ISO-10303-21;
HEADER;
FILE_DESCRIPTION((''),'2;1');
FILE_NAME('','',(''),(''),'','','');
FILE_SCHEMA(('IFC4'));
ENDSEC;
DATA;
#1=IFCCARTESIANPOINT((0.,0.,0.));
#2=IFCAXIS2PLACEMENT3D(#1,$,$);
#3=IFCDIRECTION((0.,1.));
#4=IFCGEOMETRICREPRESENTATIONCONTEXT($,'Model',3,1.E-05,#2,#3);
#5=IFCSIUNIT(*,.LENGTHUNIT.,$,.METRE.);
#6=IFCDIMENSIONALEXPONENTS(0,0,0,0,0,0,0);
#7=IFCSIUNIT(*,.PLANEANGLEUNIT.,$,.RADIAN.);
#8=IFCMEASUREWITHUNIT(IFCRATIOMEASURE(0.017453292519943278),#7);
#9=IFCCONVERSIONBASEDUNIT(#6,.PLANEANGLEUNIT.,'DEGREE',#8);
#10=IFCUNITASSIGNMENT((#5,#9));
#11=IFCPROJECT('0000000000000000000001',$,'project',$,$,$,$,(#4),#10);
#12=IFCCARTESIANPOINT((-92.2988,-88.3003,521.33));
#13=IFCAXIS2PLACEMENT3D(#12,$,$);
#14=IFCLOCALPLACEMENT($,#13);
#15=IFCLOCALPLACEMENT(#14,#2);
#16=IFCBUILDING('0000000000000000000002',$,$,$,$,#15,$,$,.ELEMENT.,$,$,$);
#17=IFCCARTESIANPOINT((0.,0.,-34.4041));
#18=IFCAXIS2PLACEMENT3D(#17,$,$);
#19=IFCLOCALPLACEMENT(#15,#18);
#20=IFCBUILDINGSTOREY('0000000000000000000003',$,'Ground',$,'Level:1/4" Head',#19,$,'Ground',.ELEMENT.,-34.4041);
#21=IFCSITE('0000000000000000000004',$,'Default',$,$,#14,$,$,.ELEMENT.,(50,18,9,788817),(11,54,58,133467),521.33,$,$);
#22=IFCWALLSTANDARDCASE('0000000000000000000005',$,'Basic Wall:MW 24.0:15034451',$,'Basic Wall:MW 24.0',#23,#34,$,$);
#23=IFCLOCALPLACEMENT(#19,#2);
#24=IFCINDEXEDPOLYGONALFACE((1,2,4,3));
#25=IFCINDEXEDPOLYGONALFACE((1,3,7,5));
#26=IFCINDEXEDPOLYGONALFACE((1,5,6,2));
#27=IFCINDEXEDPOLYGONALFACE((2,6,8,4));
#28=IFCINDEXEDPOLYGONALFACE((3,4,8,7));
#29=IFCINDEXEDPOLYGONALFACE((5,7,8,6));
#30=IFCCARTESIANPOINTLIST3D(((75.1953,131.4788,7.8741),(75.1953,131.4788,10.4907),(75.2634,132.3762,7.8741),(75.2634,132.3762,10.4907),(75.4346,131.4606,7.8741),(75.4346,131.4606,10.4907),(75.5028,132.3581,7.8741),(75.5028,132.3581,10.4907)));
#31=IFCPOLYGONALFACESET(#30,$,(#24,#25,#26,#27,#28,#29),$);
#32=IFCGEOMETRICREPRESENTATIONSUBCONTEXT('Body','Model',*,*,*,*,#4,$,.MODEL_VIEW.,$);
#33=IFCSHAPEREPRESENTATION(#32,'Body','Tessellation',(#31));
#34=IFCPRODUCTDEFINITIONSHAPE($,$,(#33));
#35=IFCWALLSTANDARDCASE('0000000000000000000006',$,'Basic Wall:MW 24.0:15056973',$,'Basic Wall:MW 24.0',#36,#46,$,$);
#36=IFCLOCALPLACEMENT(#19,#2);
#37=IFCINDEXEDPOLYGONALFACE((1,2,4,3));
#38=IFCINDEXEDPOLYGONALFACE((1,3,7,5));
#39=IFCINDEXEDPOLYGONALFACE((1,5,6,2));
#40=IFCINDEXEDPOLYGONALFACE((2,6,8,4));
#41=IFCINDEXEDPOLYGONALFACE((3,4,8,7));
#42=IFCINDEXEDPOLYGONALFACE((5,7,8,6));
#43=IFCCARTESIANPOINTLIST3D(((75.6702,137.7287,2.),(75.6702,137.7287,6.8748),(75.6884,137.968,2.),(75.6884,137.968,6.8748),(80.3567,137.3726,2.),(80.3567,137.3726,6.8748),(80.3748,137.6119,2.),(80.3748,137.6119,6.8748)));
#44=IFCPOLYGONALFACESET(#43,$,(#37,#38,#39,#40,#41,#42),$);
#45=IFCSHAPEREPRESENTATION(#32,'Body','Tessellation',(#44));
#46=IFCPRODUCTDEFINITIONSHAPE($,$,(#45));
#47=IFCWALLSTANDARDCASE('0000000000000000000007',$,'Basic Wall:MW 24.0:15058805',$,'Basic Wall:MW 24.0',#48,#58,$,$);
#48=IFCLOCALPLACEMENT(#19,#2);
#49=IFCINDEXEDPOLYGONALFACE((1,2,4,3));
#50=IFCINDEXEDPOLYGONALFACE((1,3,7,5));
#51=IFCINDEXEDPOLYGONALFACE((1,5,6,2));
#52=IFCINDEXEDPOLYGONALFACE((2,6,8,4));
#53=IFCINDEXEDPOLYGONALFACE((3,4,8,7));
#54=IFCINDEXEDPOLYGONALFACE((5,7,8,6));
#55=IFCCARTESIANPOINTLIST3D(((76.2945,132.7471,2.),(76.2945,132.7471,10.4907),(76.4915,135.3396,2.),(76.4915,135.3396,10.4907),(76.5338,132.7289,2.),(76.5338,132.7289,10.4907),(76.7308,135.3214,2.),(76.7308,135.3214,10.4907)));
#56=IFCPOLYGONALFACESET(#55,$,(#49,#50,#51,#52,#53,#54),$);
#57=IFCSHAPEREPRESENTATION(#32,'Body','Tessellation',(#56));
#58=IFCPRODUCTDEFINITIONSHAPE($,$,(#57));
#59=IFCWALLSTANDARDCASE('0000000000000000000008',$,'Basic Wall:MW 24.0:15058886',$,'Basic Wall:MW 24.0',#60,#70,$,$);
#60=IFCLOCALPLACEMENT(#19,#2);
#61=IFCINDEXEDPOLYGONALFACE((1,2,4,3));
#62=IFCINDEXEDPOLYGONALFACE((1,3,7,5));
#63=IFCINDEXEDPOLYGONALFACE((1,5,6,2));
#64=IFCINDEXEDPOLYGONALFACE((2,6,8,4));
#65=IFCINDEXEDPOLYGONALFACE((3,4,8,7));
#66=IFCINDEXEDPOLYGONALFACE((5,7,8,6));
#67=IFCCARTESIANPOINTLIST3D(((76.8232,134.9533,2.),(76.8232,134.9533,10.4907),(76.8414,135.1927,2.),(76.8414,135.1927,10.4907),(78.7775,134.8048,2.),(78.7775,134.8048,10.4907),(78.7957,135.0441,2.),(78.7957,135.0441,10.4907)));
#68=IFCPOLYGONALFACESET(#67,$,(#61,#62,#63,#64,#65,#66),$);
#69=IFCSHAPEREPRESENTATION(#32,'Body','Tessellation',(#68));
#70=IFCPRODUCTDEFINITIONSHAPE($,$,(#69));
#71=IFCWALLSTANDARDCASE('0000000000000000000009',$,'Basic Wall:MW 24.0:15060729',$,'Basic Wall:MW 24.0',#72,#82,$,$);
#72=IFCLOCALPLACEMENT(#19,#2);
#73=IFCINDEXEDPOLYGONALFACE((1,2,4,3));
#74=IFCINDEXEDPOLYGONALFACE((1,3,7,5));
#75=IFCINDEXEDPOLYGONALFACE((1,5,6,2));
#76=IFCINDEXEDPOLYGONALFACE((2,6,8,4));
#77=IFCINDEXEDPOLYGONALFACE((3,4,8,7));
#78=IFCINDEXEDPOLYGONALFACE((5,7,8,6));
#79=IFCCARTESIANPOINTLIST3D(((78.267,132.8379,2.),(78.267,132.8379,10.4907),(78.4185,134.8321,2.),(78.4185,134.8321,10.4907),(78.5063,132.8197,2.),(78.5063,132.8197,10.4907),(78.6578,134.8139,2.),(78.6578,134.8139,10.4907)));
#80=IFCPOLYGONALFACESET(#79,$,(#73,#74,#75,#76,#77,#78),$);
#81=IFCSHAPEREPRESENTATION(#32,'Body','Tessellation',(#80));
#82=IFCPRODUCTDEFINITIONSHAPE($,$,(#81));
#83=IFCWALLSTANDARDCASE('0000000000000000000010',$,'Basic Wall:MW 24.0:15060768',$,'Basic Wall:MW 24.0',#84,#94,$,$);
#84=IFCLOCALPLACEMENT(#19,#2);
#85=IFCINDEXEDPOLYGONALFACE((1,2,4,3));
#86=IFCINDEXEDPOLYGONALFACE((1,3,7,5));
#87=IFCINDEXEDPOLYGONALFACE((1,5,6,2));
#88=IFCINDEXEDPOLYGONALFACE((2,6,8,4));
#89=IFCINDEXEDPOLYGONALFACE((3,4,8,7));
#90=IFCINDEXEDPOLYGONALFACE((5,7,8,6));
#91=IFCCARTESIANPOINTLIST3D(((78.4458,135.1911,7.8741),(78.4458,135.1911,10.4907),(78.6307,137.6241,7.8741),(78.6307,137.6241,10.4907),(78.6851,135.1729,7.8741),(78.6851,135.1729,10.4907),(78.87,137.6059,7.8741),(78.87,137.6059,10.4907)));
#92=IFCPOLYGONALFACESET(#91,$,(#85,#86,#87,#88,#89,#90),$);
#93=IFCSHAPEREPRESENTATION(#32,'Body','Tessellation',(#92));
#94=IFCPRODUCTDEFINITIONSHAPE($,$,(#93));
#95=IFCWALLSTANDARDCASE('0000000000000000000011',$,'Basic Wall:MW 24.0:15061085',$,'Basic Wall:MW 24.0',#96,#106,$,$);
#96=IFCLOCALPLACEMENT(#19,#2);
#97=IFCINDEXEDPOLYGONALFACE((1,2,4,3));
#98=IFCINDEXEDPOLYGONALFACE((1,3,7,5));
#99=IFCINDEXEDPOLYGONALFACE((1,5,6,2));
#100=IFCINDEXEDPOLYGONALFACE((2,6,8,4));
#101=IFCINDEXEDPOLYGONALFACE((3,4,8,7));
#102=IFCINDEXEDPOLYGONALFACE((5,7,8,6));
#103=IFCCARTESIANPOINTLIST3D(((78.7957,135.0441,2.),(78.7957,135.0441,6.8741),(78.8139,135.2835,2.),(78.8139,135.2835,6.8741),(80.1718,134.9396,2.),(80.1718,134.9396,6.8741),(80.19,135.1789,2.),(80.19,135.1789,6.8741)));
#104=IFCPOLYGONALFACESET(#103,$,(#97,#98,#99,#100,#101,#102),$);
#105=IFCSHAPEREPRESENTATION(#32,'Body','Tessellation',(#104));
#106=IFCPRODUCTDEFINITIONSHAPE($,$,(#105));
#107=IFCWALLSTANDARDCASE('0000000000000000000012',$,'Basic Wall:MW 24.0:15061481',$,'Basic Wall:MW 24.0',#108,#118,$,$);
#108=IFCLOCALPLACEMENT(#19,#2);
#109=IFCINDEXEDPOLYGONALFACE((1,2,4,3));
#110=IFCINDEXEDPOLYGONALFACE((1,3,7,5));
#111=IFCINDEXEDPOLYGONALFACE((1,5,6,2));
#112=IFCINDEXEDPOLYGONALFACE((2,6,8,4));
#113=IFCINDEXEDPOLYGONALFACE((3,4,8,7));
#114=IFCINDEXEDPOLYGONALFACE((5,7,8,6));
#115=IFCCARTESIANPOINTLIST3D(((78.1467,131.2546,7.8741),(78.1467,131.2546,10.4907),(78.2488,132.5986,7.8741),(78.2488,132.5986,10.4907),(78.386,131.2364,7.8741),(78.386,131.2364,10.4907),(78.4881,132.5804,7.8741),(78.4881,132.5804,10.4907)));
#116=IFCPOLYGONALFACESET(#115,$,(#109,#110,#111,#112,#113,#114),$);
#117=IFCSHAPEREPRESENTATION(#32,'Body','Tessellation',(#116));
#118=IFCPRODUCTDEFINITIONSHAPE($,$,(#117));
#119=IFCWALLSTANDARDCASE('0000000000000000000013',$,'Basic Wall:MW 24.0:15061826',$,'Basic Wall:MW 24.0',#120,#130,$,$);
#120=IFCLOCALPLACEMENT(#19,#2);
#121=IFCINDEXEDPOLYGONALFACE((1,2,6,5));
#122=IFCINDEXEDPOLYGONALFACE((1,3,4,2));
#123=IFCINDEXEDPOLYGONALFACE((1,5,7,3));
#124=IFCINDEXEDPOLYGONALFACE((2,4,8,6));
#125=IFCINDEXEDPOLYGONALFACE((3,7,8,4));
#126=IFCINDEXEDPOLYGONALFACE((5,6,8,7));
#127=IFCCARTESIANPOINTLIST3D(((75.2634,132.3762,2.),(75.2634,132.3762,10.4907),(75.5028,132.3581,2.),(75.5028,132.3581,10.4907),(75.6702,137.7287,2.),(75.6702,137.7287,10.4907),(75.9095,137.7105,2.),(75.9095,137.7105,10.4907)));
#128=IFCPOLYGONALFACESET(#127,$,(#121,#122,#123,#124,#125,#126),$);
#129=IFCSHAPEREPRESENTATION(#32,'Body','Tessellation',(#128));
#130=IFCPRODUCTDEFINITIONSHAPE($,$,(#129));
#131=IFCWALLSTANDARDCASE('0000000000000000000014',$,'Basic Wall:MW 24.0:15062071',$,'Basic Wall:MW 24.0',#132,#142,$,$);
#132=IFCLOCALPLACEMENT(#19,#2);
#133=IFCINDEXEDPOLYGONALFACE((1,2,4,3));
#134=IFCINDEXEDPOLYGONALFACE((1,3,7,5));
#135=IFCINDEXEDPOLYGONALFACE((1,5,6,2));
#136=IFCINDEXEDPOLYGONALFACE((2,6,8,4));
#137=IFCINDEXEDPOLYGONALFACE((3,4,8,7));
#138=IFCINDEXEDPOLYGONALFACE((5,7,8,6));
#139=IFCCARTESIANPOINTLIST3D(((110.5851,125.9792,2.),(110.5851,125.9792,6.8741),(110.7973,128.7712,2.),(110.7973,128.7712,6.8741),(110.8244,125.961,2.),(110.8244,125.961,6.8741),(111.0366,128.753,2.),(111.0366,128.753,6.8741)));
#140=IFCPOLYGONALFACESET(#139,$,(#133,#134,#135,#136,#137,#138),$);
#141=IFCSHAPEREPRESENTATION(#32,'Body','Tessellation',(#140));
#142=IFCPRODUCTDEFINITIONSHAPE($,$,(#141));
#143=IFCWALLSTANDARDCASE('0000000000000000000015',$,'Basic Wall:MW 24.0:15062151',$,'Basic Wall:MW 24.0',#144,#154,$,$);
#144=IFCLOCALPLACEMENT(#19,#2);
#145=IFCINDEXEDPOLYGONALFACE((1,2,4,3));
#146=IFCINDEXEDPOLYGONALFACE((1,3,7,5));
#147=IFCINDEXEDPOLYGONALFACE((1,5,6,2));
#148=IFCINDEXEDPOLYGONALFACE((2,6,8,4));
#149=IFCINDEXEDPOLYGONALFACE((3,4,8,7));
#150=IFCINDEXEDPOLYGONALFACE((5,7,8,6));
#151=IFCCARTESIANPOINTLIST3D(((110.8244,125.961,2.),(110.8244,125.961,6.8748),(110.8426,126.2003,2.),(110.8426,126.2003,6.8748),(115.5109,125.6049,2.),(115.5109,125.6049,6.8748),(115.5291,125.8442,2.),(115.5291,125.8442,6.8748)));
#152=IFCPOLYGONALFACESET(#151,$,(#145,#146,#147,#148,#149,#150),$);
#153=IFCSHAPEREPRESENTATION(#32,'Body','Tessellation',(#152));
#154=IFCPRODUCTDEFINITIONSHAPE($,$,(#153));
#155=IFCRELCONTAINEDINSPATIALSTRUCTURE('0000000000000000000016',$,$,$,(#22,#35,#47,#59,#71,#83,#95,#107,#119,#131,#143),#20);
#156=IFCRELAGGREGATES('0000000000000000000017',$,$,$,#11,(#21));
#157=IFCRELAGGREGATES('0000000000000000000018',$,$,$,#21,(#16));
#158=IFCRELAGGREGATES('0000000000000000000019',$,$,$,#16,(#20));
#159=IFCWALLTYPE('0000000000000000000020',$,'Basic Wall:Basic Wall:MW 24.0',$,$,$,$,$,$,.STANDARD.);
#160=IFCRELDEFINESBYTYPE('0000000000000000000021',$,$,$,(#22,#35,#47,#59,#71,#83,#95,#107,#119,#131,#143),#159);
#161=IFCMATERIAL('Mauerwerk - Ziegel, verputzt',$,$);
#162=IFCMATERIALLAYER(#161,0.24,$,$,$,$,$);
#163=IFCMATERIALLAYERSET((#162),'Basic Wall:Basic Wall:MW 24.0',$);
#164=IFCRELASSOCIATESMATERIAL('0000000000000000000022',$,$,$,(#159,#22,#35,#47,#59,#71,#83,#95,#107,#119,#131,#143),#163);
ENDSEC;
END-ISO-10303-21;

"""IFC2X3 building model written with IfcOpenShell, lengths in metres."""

from ifc_helpers import new_model, entity, si_unit, converted_unit, direction, frame, frame_2d, origin, place, context, subcontext, project, spatial, rectangle, extrude, material, layer, layer_set, layer_usage, type_object, element, save


model = new_model("IFC2X3")

# Units and contexts
model_context = context("Model", 3, precision=1e-05, world=origin(), true_north=direction((0.0, 1.0)))
body_context = subcontext(model_context, "Body", "Model", "MODEL_VIEW")
ifc_project = project(units=[si_unit("LENGTHUNIT", "METRE"), converted_unit("PLANEANGLEUNIT", "DEGREE", entity("IfcRatioMeasure", 0.017453292519943278), si_unit("PLANEANGLEUNIT", "RADIAN"), dimensions=[0, 0, 0, 0, 0, 0, 0])], contexts=[model_context])

# Site, building, storey
site_placement = place(None, frame((-92.2988, -88.3003, 521.33)))
site = spatial("IfcSite", under=ifc_project, at=site_placement, Name="Default", CompositionType="ELEMENT", RefLatitude=(50, 18, 9, 788817), RefLongitude=(11, 54, 58, 133467), RefElevation=521.33)
building_placement = place(site_placement, origin())
building = spatial("IfcBuilding", under=site, at=building_placement, CompositionType="ELEMENT")
storey_placement = place(building_placement, frame((0.0, 0.0, -34.4041)))
storey = spatial("IfcBuildingStorey", under=building, at=storey_placement, Name="Ground", ObjectType="Level:1/4\" Head", LongName="Ground", CompositionType="ELEMENT", Elevation=-34.4041)

# Walls
ifc_material_1 = material(Name="Mauerwerk - Ziegel, verputzt")
ifc_layer = layer(ifc_material_1, 0.24)
ifc_layer_set = layer_set([ifc_layer], Name="Basic Wall:Basic Wall:MW 24.0")
wall_type_1 = type_object("IfcWallType", Name="Basic Wall:Basic Wall:MW 24.0", PredefinedType="STANDARD", material=ifc_layer_set)
ifc_layer_usage_1 = layer_usage(ifc_layer_set, "AXIS2", "NEGATIVE", 0.12)
wall_1_placement = place(storey_placement, frame((75.3149, 131.4697, 7.8741), z_axis=(0.0, 0.0, 1.0), x_axis=(0.07577, 0.997125, 0.0)))
element("IfcWallStandardCase", 1, at=wall_1_placement, inside=storey, type_object=wall_type_1, material=ifc_layer_usage_1, Name="Basic Wall:MW 24.0:15034451", ObjectType="Basic Wall:MW 24.0", context=body_context, shape_type="SweptSolid", body=[
    extrude(rectangle(XDim=0.9, YDim=0.24, at=frame_2d((0.45, 0.0), x_axis=(-1.0, 0.0))), origin(), (0.0, 0.0, 1.0), 2.6166),
])
ifc_layer_usage_2 = layer_usage(ifc_layer_set, "AXIS2", "NEGATIVE", 0.12)
wall_2_placement = place(storey_placement, frame((80.3657, 137.4922, 2.0), z_axis=(0.0, 0.0, 1.0), x_axis=(-0.997125, 0.07577, 0.0)))
element("IfcWallStandardCase", 2, at=wall_2_placement, inside=storey, type_object=wall_type_1, material=ifc_layer_usage_2, Name="Basic Wall:MW 24.0:15056973", ObjectType="Basic Wall:MW 24.0", context=body_context, shape_type="SweptSolid", body=[
    extrude(rectangle(XDim=4.7, YDim=0.24, at=frame_2d((2.35, 0.0), x_axis=(-1.0, 0.0))), origin(), (0.0, 0.0, 1.0), 4.8748),
])
ifc_layer_usage_3 = layer_usage(ifc_layer_set, "AXIS2", "NEGATIVE", 0.12)
wall_3_placement = place(storey_placement, frame((76.6112, 135.3305, 2.0), z_axis=(0.0, 0.0, 1.0), x_axis=(-0.07577, -0.997125, 0.0)))
element("IfcWallStandardCase", 3, at=wall_3_placement, inside=storey, type_object=wall_type_1, material=ifc_layer_usage_3, Name="Basic Wall:MW 24.0:15058805", ObjectType="Basic Wall:MW 24.0", context=body_context, shape_type="SweptSolid", body=[
    extrude(rectangle(XDim=2.6, YDim=0.24, at=frame_2d((1.3, 0.0), x_axis=(-1.0, 0.0))), origin(), (0.0, 0.0, 1.0), 8.4907),
])
ifc_layer_usage_4 = layer_usage(ifc_layer_set, "AXIS2", "NEGATIVE", 0.12)
wall_4_placement = place(storey_placement, frame((76.8323, 135.073, 2.0), z_axis=(0.0, 0.0, 1.0), x_axis=(0.997125, -0.07577, 0.0)))
element("IfcWallStandardCase", 4, at=wall_4_placement, inside=storey, type_object=wall_type_1, material=ifc_layer_usage_4, Name="Basic Wall:MW 24.0:15058886", ObjectType="Basic Wall:MW 24.0", context=body_context, shape_type="SweptSolid", body=[
    extrude(rectangle(XDim=1.9599, YDim=0.24, at=frame_2d((0.98, 0.0), x_axis=(-1.0, 0.0))), origin(), (0.0, 0.0, 1.0), 8.4907),
])
ifc_layer_usage_5 = layer_usage(ifc_layer_set, "AXIS2", "NEGATIVE", 0.12)
wall_5_placement = place(storey_placement, frame((78.5382, 134.823, 2.0), z_axis=(0.0, 0.0, 1.0), x_axis=(-0.07577, -0.997125, 0.0)))
element("IfcWallStandardCase", 5, at=wall_5_placement, inside=storey, type_object=wall_type_1, material=ifc_layer_usage_5, Name="Basic Wall:MW 24.0:15060729", ObjectType="Basic Wall:MW 24.0", context=body_context, shape_type="SweptSolid", body=[
    extrude(rectangle(XDim=2.0, YDim=0.24, at=frame_2d((1.0, 0.0), x_axis=(-1.0, 0.0))), origin(), (0.0, 0.0, 1.0), 8.4907),
])
ifc_layer_usage_6 = layer_usage(ifc_layer_set, "AXIS2", "NEGATIVE", 0.12)
wall_6_placement = place(storey_placement, frame((78.7503, 137.615, 7.8741), z_axis=(0.0, 0.0, 1.0), x_axis=(-0.07577, -0.997125, 0.0)))
element("IfcWallStandardCase", 6, at=wall_6_placement, inside=storey, type_object=wall_type_1, material=ifc_layer_usage_6, Name="Basic Wall:MW 24.0:15060768", ObjectType="Basic Wall:MW 24.0", context=body_context, shape_type="SweptSolid", body=[
    extrude(rectangle(XDim=2.44, YDim=0.24, at=frame_2d((1.22, 0.0), x_axis=(-1.0, 0.0))), origin(), (0.0, 0.0, 1.0), 2.6166),
])
ifc_layer_usage_7 = layer_usage(ifc_layer_set, "AXIS2", "NEGATIVE", 0.12)
wall_7_placement = place(storey_placement, frame((80.1809, 135.0592, 2.0), z_axis=(0.0, 0.0, 1.0), x_axis=(-0.997125, 0.07577, 0.0)))
element("IfcWallStandardCase", 7, at=wall_7_placement, inside=storey, type_object=wall_type_1, material=ifc_layer_usage_7, Name="Basic Wall:MW 24.0:15061085", ObjectType="Basic Wall:MW 24.0", context=body_context, shape_type="SweptSolid", body=[
    extrude(rectangle(XDim=1.3801, YDim=0.24, at=frame_2d((0.69, 0.0), x_axis=(-1.0, 0.0))), origin(), (0.0, 0.0, 1.0), 4.8741),
])
ifc_layer_usage_8 = layer_usage(ifc_layer_set, "AXIS2", "NEGATIVE", 0.12)
wall_8_placement = place(storey_placement, frame((78.3685, 132.5895, 7.8741), z_axis=(0.0, 0.0, 1.0), x_axis=(-0.07577, -0.997125, 0.0)))
element("IfcWallStandardCase", 8, at=wall_8_placement, inside=storey, type_object=wall_type_1, material=ifc_layer_usage_8, Name="Basic Wall:MW 24.0:15061481", ObjectType="Basic Wall:MW 24.0", context=body_context, shape_type="SweptSolid", body=[
    extrude(rectangle(XDim=1.3479, YDim=0.24, at=frame_2d((0.6739, 0.0), x_axis=(-1.0, 0.0))), origin(), (0.0, 0.0, 1.0), 2.6166),
])
ifc_layer_usage_9 = layer_usage(ifc_layer_set, "AXIS2", "NEGATIVE", 0.12)
wall_9_placement = place(storey_placement, frame((75.3831, 132.3672, 2.0), z_axis=(0.0, 0.0, 1.0), x_axis=(0.07577, 0.997125, 0.0)))
element("IfcWallStandardCase", 9, at=wall_9_placement, inside=storey, type_object=wall_type_1, material=ifc_layer_usage_9, Name="Basic Wall:MW 24.0:15061826", ObjectType="Basic Wall:MW 24.0", context=body_context, shape_type="SweptSolid", body=[
    extrude(rectangle(XDim=5.3679, YDim=0.24, at=frame_2d((2.6839, 0.0), x_axis=(-1.0, 0.0))), origin(), (0.0, 0.0, 1.0), 8.4907),
])
ifc_layer_usage_10 = layer_usage(ifc_layer_set, "AXIS2", "NEGATIVE", 0.12)
wall_10_placement = place(storey_placement, frame((110.7048, 125.9701, 2.0), z_axis=(0.0, 0.0, 1.0), x_axis=(0.07577, 0.997125, 0.0)))
element("IfcWallStandardCase", 10, at=wall_10_placement, inside=storey, type_object=wall_type_1, material=ifc_layer_usage_10, Name="Basic Wall:MW 24.0:15062071", ObjectType="Basic Wall:MW 24.0", context=body_context, shape_type="SweptSolid", body=[
    extrude(rectangle(XDim=2.8, YDim=0.24, at=frame_2d((1.4, 0.0), x_axis=(-1.0, 0.0))), origin(), (0.0, 0.0, 1.0), 4.8741),
])
ifc_layer_usage_11 = layer_usage(ifc_layer_set, "AXIS2", "NEGATIVE", 0.12)
wall_11_placement = place(storey_placement, frame((110.8335, 126.0807, 2.0), z_axis=(0.0, 0.0, 1.0), x_axis=(0.997125, -0.07577, 0.0)))
element("IfcWallStandardCase", 11, at=wall_11_placement, inside=storey, type_object=wall_type_1, material=ifc_layer_usage_11, Name="Basic Wall:MW 24.0:15062151", ObjectType="Basic Wall:MW 24.0", context=body_context, shape_type="SweptSolid", body=[
    extrude(rectangle(XDim=4.7, YDim=0.24, at=frame_2d((2.35, 0.0), x_axis=(-1.0, 0.0))), origin(), (0.0, 0.0, 1.0), 4.8748),
])

save(model, "model.ifc")
